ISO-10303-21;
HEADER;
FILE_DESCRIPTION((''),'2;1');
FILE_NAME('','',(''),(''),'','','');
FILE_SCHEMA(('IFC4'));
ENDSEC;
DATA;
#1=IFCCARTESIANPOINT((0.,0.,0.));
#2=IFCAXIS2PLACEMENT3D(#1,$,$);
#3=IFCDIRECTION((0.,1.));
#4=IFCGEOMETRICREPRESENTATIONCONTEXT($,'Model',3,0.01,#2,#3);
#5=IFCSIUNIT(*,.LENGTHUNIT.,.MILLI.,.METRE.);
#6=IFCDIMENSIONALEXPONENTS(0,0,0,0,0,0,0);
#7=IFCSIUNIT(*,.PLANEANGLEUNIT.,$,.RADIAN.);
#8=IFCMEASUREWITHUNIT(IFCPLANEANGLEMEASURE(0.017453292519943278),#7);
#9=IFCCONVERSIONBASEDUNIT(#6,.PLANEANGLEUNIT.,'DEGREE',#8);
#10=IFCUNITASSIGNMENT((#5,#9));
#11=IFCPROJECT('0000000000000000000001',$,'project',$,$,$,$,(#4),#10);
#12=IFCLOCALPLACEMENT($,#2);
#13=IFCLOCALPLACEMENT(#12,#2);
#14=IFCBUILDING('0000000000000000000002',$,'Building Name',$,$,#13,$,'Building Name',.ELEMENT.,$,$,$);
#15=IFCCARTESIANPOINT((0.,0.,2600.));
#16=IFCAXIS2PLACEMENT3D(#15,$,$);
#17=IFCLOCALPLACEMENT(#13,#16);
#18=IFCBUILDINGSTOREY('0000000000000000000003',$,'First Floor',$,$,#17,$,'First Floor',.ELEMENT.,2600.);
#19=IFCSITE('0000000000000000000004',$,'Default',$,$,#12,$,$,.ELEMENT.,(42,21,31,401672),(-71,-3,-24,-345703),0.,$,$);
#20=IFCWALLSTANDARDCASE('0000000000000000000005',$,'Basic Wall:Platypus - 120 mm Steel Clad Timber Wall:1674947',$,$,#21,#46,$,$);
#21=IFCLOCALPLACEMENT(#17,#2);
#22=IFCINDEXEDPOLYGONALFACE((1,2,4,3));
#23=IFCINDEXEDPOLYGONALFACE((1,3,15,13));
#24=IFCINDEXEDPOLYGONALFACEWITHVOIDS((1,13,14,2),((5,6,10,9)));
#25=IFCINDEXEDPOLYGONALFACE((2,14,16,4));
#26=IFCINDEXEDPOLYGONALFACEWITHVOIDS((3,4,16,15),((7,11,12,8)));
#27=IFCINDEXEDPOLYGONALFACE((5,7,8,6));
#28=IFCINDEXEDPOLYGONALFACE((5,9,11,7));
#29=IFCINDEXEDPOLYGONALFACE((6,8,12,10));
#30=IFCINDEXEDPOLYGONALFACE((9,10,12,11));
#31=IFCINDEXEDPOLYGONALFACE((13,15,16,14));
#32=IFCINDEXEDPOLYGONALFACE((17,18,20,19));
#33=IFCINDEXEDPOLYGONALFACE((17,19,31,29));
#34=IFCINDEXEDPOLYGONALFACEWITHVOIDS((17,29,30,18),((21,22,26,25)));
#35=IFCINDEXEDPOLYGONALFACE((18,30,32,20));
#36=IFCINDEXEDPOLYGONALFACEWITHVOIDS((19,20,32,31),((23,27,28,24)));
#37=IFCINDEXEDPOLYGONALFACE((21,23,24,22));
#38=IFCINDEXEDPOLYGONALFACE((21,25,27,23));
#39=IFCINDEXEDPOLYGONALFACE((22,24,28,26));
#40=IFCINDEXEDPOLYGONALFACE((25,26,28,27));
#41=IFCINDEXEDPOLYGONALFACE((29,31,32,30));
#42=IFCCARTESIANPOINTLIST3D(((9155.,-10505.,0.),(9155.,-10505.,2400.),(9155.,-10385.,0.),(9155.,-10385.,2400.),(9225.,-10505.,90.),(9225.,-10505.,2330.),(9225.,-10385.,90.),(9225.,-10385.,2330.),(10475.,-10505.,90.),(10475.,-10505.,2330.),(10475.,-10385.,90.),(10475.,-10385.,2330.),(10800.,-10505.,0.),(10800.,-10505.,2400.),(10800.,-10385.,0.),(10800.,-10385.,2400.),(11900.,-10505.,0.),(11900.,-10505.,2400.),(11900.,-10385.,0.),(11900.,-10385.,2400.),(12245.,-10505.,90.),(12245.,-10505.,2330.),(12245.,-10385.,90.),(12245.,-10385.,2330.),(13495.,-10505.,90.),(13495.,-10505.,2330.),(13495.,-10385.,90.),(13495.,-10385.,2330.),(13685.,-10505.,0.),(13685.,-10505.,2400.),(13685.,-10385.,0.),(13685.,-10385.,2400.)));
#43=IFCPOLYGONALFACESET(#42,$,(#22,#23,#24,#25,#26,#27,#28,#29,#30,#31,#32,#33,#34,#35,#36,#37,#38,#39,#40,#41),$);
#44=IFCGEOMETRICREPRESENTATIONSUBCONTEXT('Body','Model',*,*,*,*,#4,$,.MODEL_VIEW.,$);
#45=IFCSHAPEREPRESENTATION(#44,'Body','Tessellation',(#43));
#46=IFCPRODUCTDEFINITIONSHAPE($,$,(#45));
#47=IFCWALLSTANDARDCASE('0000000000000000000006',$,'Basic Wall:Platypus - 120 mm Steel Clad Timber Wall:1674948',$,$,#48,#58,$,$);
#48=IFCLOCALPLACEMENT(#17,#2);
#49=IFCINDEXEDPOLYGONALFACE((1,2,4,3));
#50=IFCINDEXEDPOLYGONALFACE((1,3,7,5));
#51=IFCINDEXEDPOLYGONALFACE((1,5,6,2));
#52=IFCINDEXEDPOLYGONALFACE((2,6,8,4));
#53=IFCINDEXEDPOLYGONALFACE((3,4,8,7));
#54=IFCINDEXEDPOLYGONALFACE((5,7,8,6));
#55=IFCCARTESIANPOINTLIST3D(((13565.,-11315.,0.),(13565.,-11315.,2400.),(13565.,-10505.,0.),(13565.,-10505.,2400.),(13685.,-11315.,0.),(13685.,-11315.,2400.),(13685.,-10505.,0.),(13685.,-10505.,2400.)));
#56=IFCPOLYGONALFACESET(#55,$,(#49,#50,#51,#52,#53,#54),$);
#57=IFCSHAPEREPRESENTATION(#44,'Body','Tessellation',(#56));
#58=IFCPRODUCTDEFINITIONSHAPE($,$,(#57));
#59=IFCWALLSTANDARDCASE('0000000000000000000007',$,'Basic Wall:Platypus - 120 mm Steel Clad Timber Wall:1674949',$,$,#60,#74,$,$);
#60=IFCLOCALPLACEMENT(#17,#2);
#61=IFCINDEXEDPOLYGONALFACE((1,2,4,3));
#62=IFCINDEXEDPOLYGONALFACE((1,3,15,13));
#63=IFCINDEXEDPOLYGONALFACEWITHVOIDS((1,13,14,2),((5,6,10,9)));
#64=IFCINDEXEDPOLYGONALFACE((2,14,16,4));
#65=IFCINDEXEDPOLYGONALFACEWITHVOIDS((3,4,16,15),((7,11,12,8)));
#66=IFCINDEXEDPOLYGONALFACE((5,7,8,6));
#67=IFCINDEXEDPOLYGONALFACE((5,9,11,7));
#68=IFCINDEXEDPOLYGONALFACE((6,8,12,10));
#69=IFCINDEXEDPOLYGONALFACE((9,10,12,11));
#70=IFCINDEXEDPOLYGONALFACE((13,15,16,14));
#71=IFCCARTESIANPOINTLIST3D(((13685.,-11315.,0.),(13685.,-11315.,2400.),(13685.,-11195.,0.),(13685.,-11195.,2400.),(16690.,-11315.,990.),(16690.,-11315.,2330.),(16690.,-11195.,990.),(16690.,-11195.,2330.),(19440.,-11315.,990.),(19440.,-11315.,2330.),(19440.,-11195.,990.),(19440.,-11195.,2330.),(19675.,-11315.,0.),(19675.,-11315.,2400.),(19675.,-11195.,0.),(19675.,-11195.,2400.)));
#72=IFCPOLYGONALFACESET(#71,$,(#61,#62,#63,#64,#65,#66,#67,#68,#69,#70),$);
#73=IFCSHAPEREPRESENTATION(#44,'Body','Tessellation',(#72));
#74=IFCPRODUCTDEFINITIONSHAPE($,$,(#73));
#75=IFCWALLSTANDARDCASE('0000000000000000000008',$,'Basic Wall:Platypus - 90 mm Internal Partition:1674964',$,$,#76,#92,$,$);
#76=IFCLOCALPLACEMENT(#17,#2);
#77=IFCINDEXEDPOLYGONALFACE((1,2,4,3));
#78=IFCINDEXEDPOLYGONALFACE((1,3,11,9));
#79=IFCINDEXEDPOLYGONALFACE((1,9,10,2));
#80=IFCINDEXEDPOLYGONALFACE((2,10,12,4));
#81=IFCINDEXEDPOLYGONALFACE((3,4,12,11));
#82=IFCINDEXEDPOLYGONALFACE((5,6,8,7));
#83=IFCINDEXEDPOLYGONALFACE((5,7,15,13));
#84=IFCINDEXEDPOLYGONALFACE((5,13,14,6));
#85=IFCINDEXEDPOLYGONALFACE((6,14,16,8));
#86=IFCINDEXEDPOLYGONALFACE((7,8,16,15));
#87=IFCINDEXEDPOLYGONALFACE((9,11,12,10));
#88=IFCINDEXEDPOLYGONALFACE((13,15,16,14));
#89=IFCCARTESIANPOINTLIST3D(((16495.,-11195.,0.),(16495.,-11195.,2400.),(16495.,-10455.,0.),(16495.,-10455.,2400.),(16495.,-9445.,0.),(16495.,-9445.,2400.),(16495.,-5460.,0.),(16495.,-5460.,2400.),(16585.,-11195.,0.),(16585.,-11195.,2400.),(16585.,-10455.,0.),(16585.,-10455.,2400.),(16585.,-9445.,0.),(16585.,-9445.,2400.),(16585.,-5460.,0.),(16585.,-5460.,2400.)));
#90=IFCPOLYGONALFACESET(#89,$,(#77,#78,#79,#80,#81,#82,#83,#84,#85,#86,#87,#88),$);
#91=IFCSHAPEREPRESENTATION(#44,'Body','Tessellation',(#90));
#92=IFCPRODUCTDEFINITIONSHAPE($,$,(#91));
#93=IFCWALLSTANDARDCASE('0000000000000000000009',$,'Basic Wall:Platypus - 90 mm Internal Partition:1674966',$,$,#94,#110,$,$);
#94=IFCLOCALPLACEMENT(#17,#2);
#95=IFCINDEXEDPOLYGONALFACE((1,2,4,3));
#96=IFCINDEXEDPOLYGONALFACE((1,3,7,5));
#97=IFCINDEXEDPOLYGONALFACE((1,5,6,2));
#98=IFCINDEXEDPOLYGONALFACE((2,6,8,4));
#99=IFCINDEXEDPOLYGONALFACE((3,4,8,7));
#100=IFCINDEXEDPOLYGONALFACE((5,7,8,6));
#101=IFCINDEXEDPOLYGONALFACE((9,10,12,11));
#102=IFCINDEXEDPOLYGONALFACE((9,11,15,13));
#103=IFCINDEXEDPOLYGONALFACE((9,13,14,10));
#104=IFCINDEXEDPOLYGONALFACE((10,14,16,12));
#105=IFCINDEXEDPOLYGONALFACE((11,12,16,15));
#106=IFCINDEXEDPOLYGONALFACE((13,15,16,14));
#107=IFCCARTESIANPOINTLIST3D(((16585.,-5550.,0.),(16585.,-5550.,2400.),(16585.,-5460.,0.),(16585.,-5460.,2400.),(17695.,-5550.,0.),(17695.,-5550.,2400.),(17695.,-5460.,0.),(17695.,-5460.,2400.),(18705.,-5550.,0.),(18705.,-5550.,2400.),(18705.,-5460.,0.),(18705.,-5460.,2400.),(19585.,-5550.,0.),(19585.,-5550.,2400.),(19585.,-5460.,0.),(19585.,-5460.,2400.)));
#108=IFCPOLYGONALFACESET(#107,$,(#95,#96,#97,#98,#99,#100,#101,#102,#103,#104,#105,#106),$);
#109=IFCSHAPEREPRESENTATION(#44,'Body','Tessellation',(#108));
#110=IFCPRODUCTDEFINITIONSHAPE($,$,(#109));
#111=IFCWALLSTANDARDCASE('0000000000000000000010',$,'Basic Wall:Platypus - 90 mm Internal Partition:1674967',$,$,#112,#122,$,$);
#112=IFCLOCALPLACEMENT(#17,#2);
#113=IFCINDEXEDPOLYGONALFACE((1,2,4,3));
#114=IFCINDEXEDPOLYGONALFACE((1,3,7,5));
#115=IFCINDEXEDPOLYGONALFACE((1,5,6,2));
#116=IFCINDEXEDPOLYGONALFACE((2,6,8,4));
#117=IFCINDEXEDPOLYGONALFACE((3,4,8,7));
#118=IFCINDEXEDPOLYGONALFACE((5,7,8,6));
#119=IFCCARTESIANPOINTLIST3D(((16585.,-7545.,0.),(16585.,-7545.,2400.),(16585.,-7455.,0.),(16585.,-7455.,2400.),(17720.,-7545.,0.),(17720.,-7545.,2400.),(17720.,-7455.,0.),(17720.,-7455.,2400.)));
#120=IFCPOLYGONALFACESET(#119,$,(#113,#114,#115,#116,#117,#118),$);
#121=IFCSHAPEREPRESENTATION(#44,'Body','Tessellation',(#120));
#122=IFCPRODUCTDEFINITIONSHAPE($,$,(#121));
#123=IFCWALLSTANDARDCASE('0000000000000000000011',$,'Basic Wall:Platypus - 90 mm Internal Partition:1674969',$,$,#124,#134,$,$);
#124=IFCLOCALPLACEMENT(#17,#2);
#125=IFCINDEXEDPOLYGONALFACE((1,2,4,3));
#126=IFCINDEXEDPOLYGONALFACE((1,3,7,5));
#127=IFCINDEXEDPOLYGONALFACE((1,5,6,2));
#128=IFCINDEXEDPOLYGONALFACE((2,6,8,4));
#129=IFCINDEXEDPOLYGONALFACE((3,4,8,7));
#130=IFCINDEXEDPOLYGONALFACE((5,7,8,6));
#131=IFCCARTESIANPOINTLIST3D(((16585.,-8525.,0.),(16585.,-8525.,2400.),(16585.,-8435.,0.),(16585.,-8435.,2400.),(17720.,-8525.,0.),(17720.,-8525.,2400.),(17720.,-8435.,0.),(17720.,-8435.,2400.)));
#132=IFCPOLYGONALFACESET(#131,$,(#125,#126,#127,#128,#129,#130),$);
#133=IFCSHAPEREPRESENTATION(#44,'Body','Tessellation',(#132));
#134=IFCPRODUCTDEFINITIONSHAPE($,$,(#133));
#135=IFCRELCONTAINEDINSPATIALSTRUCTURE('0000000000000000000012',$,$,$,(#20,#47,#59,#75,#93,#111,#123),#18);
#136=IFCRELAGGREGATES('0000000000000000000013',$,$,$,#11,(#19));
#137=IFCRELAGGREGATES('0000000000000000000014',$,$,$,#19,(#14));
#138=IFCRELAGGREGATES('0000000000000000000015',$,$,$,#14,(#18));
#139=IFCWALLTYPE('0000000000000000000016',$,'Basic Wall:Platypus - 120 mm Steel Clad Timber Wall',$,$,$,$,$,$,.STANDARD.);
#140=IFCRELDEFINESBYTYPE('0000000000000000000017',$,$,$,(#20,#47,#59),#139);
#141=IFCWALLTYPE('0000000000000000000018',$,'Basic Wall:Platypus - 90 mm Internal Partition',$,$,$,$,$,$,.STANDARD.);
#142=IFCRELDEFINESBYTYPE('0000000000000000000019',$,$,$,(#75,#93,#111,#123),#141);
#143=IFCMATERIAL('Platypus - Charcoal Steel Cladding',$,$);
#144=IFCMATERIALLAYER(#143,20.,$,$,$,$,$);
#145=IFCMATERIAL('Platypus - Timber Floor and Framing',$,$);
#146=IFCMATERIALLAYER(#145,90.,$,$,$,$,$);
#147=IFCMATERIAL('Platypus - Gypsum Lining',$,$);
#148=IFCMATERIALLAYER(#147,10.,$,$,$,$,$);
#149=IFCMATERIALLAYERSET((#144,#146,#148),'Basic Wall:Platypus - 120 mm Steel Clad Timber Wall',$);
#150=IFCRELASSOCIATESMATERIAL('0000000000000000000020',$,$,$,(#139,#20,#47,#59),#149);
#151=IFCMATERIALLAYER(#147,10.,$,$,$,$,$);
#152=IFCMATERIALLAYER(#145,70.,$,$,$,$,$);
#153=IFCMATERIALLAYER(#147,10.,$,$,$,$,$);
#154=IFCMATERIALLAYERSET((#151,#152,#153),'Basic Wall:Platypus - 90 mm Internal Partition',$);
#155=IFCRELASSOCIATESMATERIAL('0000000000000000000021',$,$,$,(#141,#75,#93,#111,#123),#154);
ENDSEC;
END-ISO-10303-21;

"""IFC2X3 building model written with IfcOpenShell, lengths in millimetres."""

from ifc_helpers import new_model, entity, si_unit, converted_unit, direction, frame, frame_2d, origin, place, context, subcontext, project, spatial, rectangle, extrude, material, layer, layer_set, layer_usage, type_object, element, save


model = new_model("IFC2X3")

# Units and contexts
model_context = context("Model", 3, precision=0.01, world=origin(), true_north=direction((0.0, 1.0)))
body_context = subcontext(model_context, "Body", "Model", "MODEL_VIEW")
ifc_project = project(units=[si_unit("LENGTHUNIT", "METRE", prefix="MILLI"), converted_unit("PLANEANGLEUNIT", "DEGREE", entity("IfcPlaneAngleMeasure", 0.017453292519943278), si_unit("PLANEANGLEUNIT", "RADIAN"), dimensions=[0, 0, 0, 0, 0, 0, 0])], contexts=[model_context])

# Site, building, storey
site_placement = place(None, origin())
site = spatial("IfcSite", under=ifc_project, at=site_placement, Name="Default", CompositionType="ELEMENT", RefLatitude=(42, 21, 31, 401672), RefLongitude=(-71, -3, -24, -345703), RefElevation=0.0)
building_placement = place(site_placement, origin())
building = spatial("IfcBuilding", under=site, at=building_placement, Name="Building Name", LongName="Building Name", CompositionType="ELEMENT")
storey_placement = place(building_placement, frame((0.0, 0.0, 2600.0)))
storey = spatial("IfcBuildingStorey", under=building, at=storey_placement, Name="First Floor", LongName="First Floor", CompositionType="ELEMENT", Elevation=2600.0)

# Wall, openings
ifc_material_1 = material(Name="Platypus - Charcoal Steel Cladding")
ifc_layer_1 = layer(ifc_material_1, 20.0)
ifc_material_2 = material(Name="Platypus - Timber Floor and Framing")
ifc_layer_2 = layer(ifc_material_2, 90.0)
ifc_material_3 = material(Name="Platypus - Gypsum Lining")
ifc_layer_3 = layer(ifc_material_3, 10.0)
ifc_layer_set_1 = layer_set([ifc_layer_1, ifc_layer_2, ifc_layer_3], Name="Basic Wall:Platypus - 120 mm Steel Clad Timber Wall")
ifc_layer_usage_1 = layer_usage(ifc_layer_set_1, "AXIS2", "POSITIVE", -60.0)
wall_type_1 = type_object("IfcWallType", Name="Basic Wall:Platypus - 120 mm Steel Clad Timber Wall", PredefinedType="STANDARD", material=ifc_layer_set_1)
wall_1_placement = place(storey_placement, frame((9155.0, -10445.0, 0.0)))
wall_1 = element("IfcWallStandardCase", 1, at=wall_1_placement, inside=storey, type_object=wall_type_1, material=ifc_layer_usage_1, Name="Basic Wall:Platypus - 120 mm Steel Clad Timber Wall:1674947", context=body_context, shape_type="SweptSolid", body=[
    extrude(rectangle(XDim=120.0, YDim=4530.0, at=frame_2d((2265.0, 0.0), x_axis=(0.0, -1.0))), origin(), (0.0, 0.0, 1.0), 2400.0),
])
opening_1_placement = place(wall_1_placement, frame((1645.0, -60.0, 0.0)))
element("IfcOpeningElement", 2, at=opening_1_placement, cuts=wall_1, ObjectType="Opening", context=body_context, shape_type="SweptSolid", body=[
    extrude(rectangle(XDim=2440.0, YDim=1100.0, at=frame_2d((1220.0, 550.0), x_axis=(1.0, 0.0))), frame((0.0, 0.0, 0.0), z_axis=(0.0, 1.0, 0.0), x_axis=(0.0, 0.0, 1.0)), (0.0, 0.0, 1.0), 120.0),
])
opening_2_placement = place(wall_1_placement, frame((70.0, -60.0, 90.0)))
element("IfcOpeningElement", 3, at=opening_2_placement, cuts=wall_1, ObjectType="Opening", context=body_context, shape_type="SweptSolid", body=[
    extrude(rectangle(XDim=2240.0, YDim=1250.0, at=frame_2d((1120.0, 625.0), x_axis=(-1.0, 0.0))), frame((0.0, 0.0, 0.0), z_axis=(0.0, 1.0, 0.0), x_axis=(0.0, 0.0, 1.0)), (0.0, 0.0, 1.0), 120.0),
])
opening_3_placement = place(wall_1_placement, frame((3090.0, -60.0, 90.0)))
element("IfcOpeningElement", 4, at=opening_3_placement, cuts=wall_1, ObjectType="Opening", context=body_context, shape_type="SweptSolid", body=[
    extrude(rectangle(XDim=2240.0, YDim=1250.0, at=frame_2d((1120.0, 625.0), x_axis=(-1.0, 0.0))), frame((0.0, 0.0, 0.0), z_axis=(0.0, 1.0, 0.0), x_axis=(0.0, 0.0, 1.0)), (0.0, 0.0, 1.0), 120.0),
])

# Wall
ifc_layer_usage_2 = layer_usage(ifc_layer_set_1, "AXIS2", "POSITIVE", -60.0)
wall_2_placement = place(storey_placement, frame((13625.0, -10505.0, 0.0), z_axis=(0.0, 0.0, 1.0), x_axis=(0.0, -1.0, 0.0)))
element("IfcWallStandardCase", 5, at=wall_2_placement, inside=storey, type_object=wall_type_1, material=ifc_layer_usage_2, Name="Basic Wall:Platypus - 120 mm Steel Clad Timber Wall:1674948", context=body_context, shape_type="SweptSolid", body=[
    extrude(rectangle(XDim=810.0, YDim=120.0, at=frame_2d((405.0, 0.0), x_axis=(-1.0, 0.0))), origin(), (0.0, 0.0, 1.0), 2400.0),
])

# Walls, openings
ifc_layer_usage_3 = layer_usage(ifc_layer_set_1, "AXIS2", "POSITIVE", -60.0)
wall_3_placement = place(storey_placement, frame((13685.0, -11255.0, 0.0)))
wall_3 = element("IfcWallStandardCase", 6, at=wall_3_placement, inside=storey, type_object=wall_type_1, material=ifc_layer_usage_3, Name="Basic Wall:Platypus - 120 mm Steel Clad Timber Wall:1674949", context=body_context, shape_type="SweptSolid", body=[
    extrude(rectangle(XDim=5990.0, YDim=120.0, at=frame_2d((2995.0, 0.0), x_axis=(-1.0, 0.0))), origin(), (0.0, 0.0, 1.0), 2400.0),
])
opening_4_placement = place(wall_3_placement, frame((3005.0, -60.0, 990.0)))
element("IfcOpeningElement", 7, at=opening_4_placement, cuts=wall_3, ObjectType="Opening", context=body_context, shape_type="SweptSolid", body=[
    extrude(rectangle(XDim=1340.0, YDim=2750.0, at=frame_2d((670.0, 1375.0), x_axis=(-1.0, 0.0))), frame((0.0, 0.0, 0.0), z_axis=(0.0, 1.0, 0.0), x_axis=(0.0, 0.0, 1.0)), (0.0, 0.0, 1.0), 120.0),
])
ifc_layer_4 = layer(ifc_material_3, 10.0)
ifc_layer_5 = layer(ifc_material_2, 70.0)
ifc_layer_6 = layer(ifc_material_3, 10.0)
ifc_layer_set_2 = layer_set([ifc_layer_4, ifc_layer_5, ifc_layer_6], Name="Basic Wall:Platypus - 90 mm Internal Partition")
ifc_layer_usage_4 = layer_usage(ifc_layer_set_2, "AXIS2", "NEGATIVE", 45.0)
wall_type_2 = type_object("IfcWallType", Name="Basic Wall:Platypus - 90 mm Internal Partition", PredefinedType="STANDARD", material=ifc_layer_set_2)
wall_4_placement = place(storey_placement, frame((16540.0, -5460.0, 0.0), z_axis=(0.0, 0.0, 1.0), x_axis=(0.0, -1.0, 0.0)))
wall_4 = element("IfcWallStandardCase", 8, at=wall_4_placement, inside=storey, type_object=wall_type_2, material=ifc_layer_usage_4, Name="Basic Wall:Platypus - 90 mm Internal Partition:1674964", context=body_context, shape_type="SweptSolid", body=[
    extrude(rectangle(XDim=5735.0, YDim=90.0, at=frame_2d((2867.5, 0.0), x_axis=(-1.0, 0.0))), origin(), (0.0, 0.0, 1.0), 2400.0),
])
opening_5_placement = place(wall_4_placement, frame((3985.0, -45.0, 0.0)))
element("IfcOpeningElement", 9, at=opening_5_placement, cuts=wall_4, ObjectType="Opening", context=body_context, shape_type="SweptSolid", body=[
    extrude(rectangle(XDim=2440.0, YDim=1010.0, at=frame_2d((1220.0, 505.0), x_axis=(1.0, 0.0))), frame((0.0, 0.0, 0.0), z_axis=(0.0, 1.0, 0.0), x_axis=(0.0, 0.0, 1.0)), (0.0, 0.0, 1.0), 90.0),
])
ifc_layer_usage_5 = layer_usage(ifc_layer_set_2, "AXIS2", "NEGATIVE", 45.0)
wall_5_placement = place(storey_placement, frame((16585.0, -5505.0, 0.0)))
wall_5 = element("IfcWallStandardCase", 10, at=wall_5_placement, inside=storey, type_object=wall_type_2, material=ifc_layer_usage_5, Name="Basic Wall:Platypus - 90 mm Internal Partition:1674966", context=body_context, shape_type="SweptSolid", body=[
    extrude(rectangle(XDim=90.0, YDim=3000.0, at=frame_2d((1500.0, 0.0), x_axis=(0.0, -1.0))), origin(), (0.0, 0.0, 1.0), 2400.0),
])
opening_6_placement = place(wall_5_placement, frame((1110.0, -45.0, 0.0)))
element("IfcOpeningElement", 11, at=opening_6_placement, cuts=wall_5, ObjectType="Opening", context=body_context, shape_type="SweptSolid", body=[
    extrude(rectangle(XDim=2440.0, YDim=1010.0, at=frame_2d((1220.0, 505.0), x_axis=(1.0, 0.0))), frame((0.0, 0.0, 0.0), z_axis=(0.0, 1.0, 0.0), x_axis=(0.0, 0.0, 1.0)), (0.0, 0.0, 1.0), 90.0),
])

# Walls
ifc_layer_usage_6 = layer_usage(ifc_layer_set_2, "AXIS2", "NEGATIVE", 45.0)
wall_6_placement = place(storey_placement, frame((16585.0, -7500.0, 0.0)))
element("IfcWallStandardCase", 12, at=wall_6_placement, inside=storey, type_object=wall_type_2, material=ifc_layer_usage_6, Name="Basic Wall:Platypus - 90 mm Internal Partition:1674967", context=body_context, shape_type="SweptSolid", body=[
    extrude(rectangle(XDim=1135.0, YDim=90.0, at=frame_2d((567.5, 0.0), x_axis=(-1.0, 0.0))), origin(), (0.0, 0.0, 1.0), 2400.0),
])
ifc_layer_usage_7 = layer_usage(ifc_layer_set_2, "AXIS2", "NEGATIVE", 45.0)
wall_7_placement = place(storey_placement, frame((16585.0, -8480.0, 0.0)))
element("IfcWallStandardCase", 13, at=wall_7_placement, inside=storey, type_object=wall_type_2, material=ifc_layer_usage_7, Name="Basic Wall:Platypus - 90 mm Internal Partition:1674969", context=body_context, shape_type="SweptSolid", body=[
    extrude(rectangle(XDim=1135.0, YDim=90.0, at=frame_2d((567.5, 0.0), x_axis=(-1.0, 0.0))), origin(), (0.0, 0.0, 1.0), 2400.0),
])

save(model, "model.ifc")
